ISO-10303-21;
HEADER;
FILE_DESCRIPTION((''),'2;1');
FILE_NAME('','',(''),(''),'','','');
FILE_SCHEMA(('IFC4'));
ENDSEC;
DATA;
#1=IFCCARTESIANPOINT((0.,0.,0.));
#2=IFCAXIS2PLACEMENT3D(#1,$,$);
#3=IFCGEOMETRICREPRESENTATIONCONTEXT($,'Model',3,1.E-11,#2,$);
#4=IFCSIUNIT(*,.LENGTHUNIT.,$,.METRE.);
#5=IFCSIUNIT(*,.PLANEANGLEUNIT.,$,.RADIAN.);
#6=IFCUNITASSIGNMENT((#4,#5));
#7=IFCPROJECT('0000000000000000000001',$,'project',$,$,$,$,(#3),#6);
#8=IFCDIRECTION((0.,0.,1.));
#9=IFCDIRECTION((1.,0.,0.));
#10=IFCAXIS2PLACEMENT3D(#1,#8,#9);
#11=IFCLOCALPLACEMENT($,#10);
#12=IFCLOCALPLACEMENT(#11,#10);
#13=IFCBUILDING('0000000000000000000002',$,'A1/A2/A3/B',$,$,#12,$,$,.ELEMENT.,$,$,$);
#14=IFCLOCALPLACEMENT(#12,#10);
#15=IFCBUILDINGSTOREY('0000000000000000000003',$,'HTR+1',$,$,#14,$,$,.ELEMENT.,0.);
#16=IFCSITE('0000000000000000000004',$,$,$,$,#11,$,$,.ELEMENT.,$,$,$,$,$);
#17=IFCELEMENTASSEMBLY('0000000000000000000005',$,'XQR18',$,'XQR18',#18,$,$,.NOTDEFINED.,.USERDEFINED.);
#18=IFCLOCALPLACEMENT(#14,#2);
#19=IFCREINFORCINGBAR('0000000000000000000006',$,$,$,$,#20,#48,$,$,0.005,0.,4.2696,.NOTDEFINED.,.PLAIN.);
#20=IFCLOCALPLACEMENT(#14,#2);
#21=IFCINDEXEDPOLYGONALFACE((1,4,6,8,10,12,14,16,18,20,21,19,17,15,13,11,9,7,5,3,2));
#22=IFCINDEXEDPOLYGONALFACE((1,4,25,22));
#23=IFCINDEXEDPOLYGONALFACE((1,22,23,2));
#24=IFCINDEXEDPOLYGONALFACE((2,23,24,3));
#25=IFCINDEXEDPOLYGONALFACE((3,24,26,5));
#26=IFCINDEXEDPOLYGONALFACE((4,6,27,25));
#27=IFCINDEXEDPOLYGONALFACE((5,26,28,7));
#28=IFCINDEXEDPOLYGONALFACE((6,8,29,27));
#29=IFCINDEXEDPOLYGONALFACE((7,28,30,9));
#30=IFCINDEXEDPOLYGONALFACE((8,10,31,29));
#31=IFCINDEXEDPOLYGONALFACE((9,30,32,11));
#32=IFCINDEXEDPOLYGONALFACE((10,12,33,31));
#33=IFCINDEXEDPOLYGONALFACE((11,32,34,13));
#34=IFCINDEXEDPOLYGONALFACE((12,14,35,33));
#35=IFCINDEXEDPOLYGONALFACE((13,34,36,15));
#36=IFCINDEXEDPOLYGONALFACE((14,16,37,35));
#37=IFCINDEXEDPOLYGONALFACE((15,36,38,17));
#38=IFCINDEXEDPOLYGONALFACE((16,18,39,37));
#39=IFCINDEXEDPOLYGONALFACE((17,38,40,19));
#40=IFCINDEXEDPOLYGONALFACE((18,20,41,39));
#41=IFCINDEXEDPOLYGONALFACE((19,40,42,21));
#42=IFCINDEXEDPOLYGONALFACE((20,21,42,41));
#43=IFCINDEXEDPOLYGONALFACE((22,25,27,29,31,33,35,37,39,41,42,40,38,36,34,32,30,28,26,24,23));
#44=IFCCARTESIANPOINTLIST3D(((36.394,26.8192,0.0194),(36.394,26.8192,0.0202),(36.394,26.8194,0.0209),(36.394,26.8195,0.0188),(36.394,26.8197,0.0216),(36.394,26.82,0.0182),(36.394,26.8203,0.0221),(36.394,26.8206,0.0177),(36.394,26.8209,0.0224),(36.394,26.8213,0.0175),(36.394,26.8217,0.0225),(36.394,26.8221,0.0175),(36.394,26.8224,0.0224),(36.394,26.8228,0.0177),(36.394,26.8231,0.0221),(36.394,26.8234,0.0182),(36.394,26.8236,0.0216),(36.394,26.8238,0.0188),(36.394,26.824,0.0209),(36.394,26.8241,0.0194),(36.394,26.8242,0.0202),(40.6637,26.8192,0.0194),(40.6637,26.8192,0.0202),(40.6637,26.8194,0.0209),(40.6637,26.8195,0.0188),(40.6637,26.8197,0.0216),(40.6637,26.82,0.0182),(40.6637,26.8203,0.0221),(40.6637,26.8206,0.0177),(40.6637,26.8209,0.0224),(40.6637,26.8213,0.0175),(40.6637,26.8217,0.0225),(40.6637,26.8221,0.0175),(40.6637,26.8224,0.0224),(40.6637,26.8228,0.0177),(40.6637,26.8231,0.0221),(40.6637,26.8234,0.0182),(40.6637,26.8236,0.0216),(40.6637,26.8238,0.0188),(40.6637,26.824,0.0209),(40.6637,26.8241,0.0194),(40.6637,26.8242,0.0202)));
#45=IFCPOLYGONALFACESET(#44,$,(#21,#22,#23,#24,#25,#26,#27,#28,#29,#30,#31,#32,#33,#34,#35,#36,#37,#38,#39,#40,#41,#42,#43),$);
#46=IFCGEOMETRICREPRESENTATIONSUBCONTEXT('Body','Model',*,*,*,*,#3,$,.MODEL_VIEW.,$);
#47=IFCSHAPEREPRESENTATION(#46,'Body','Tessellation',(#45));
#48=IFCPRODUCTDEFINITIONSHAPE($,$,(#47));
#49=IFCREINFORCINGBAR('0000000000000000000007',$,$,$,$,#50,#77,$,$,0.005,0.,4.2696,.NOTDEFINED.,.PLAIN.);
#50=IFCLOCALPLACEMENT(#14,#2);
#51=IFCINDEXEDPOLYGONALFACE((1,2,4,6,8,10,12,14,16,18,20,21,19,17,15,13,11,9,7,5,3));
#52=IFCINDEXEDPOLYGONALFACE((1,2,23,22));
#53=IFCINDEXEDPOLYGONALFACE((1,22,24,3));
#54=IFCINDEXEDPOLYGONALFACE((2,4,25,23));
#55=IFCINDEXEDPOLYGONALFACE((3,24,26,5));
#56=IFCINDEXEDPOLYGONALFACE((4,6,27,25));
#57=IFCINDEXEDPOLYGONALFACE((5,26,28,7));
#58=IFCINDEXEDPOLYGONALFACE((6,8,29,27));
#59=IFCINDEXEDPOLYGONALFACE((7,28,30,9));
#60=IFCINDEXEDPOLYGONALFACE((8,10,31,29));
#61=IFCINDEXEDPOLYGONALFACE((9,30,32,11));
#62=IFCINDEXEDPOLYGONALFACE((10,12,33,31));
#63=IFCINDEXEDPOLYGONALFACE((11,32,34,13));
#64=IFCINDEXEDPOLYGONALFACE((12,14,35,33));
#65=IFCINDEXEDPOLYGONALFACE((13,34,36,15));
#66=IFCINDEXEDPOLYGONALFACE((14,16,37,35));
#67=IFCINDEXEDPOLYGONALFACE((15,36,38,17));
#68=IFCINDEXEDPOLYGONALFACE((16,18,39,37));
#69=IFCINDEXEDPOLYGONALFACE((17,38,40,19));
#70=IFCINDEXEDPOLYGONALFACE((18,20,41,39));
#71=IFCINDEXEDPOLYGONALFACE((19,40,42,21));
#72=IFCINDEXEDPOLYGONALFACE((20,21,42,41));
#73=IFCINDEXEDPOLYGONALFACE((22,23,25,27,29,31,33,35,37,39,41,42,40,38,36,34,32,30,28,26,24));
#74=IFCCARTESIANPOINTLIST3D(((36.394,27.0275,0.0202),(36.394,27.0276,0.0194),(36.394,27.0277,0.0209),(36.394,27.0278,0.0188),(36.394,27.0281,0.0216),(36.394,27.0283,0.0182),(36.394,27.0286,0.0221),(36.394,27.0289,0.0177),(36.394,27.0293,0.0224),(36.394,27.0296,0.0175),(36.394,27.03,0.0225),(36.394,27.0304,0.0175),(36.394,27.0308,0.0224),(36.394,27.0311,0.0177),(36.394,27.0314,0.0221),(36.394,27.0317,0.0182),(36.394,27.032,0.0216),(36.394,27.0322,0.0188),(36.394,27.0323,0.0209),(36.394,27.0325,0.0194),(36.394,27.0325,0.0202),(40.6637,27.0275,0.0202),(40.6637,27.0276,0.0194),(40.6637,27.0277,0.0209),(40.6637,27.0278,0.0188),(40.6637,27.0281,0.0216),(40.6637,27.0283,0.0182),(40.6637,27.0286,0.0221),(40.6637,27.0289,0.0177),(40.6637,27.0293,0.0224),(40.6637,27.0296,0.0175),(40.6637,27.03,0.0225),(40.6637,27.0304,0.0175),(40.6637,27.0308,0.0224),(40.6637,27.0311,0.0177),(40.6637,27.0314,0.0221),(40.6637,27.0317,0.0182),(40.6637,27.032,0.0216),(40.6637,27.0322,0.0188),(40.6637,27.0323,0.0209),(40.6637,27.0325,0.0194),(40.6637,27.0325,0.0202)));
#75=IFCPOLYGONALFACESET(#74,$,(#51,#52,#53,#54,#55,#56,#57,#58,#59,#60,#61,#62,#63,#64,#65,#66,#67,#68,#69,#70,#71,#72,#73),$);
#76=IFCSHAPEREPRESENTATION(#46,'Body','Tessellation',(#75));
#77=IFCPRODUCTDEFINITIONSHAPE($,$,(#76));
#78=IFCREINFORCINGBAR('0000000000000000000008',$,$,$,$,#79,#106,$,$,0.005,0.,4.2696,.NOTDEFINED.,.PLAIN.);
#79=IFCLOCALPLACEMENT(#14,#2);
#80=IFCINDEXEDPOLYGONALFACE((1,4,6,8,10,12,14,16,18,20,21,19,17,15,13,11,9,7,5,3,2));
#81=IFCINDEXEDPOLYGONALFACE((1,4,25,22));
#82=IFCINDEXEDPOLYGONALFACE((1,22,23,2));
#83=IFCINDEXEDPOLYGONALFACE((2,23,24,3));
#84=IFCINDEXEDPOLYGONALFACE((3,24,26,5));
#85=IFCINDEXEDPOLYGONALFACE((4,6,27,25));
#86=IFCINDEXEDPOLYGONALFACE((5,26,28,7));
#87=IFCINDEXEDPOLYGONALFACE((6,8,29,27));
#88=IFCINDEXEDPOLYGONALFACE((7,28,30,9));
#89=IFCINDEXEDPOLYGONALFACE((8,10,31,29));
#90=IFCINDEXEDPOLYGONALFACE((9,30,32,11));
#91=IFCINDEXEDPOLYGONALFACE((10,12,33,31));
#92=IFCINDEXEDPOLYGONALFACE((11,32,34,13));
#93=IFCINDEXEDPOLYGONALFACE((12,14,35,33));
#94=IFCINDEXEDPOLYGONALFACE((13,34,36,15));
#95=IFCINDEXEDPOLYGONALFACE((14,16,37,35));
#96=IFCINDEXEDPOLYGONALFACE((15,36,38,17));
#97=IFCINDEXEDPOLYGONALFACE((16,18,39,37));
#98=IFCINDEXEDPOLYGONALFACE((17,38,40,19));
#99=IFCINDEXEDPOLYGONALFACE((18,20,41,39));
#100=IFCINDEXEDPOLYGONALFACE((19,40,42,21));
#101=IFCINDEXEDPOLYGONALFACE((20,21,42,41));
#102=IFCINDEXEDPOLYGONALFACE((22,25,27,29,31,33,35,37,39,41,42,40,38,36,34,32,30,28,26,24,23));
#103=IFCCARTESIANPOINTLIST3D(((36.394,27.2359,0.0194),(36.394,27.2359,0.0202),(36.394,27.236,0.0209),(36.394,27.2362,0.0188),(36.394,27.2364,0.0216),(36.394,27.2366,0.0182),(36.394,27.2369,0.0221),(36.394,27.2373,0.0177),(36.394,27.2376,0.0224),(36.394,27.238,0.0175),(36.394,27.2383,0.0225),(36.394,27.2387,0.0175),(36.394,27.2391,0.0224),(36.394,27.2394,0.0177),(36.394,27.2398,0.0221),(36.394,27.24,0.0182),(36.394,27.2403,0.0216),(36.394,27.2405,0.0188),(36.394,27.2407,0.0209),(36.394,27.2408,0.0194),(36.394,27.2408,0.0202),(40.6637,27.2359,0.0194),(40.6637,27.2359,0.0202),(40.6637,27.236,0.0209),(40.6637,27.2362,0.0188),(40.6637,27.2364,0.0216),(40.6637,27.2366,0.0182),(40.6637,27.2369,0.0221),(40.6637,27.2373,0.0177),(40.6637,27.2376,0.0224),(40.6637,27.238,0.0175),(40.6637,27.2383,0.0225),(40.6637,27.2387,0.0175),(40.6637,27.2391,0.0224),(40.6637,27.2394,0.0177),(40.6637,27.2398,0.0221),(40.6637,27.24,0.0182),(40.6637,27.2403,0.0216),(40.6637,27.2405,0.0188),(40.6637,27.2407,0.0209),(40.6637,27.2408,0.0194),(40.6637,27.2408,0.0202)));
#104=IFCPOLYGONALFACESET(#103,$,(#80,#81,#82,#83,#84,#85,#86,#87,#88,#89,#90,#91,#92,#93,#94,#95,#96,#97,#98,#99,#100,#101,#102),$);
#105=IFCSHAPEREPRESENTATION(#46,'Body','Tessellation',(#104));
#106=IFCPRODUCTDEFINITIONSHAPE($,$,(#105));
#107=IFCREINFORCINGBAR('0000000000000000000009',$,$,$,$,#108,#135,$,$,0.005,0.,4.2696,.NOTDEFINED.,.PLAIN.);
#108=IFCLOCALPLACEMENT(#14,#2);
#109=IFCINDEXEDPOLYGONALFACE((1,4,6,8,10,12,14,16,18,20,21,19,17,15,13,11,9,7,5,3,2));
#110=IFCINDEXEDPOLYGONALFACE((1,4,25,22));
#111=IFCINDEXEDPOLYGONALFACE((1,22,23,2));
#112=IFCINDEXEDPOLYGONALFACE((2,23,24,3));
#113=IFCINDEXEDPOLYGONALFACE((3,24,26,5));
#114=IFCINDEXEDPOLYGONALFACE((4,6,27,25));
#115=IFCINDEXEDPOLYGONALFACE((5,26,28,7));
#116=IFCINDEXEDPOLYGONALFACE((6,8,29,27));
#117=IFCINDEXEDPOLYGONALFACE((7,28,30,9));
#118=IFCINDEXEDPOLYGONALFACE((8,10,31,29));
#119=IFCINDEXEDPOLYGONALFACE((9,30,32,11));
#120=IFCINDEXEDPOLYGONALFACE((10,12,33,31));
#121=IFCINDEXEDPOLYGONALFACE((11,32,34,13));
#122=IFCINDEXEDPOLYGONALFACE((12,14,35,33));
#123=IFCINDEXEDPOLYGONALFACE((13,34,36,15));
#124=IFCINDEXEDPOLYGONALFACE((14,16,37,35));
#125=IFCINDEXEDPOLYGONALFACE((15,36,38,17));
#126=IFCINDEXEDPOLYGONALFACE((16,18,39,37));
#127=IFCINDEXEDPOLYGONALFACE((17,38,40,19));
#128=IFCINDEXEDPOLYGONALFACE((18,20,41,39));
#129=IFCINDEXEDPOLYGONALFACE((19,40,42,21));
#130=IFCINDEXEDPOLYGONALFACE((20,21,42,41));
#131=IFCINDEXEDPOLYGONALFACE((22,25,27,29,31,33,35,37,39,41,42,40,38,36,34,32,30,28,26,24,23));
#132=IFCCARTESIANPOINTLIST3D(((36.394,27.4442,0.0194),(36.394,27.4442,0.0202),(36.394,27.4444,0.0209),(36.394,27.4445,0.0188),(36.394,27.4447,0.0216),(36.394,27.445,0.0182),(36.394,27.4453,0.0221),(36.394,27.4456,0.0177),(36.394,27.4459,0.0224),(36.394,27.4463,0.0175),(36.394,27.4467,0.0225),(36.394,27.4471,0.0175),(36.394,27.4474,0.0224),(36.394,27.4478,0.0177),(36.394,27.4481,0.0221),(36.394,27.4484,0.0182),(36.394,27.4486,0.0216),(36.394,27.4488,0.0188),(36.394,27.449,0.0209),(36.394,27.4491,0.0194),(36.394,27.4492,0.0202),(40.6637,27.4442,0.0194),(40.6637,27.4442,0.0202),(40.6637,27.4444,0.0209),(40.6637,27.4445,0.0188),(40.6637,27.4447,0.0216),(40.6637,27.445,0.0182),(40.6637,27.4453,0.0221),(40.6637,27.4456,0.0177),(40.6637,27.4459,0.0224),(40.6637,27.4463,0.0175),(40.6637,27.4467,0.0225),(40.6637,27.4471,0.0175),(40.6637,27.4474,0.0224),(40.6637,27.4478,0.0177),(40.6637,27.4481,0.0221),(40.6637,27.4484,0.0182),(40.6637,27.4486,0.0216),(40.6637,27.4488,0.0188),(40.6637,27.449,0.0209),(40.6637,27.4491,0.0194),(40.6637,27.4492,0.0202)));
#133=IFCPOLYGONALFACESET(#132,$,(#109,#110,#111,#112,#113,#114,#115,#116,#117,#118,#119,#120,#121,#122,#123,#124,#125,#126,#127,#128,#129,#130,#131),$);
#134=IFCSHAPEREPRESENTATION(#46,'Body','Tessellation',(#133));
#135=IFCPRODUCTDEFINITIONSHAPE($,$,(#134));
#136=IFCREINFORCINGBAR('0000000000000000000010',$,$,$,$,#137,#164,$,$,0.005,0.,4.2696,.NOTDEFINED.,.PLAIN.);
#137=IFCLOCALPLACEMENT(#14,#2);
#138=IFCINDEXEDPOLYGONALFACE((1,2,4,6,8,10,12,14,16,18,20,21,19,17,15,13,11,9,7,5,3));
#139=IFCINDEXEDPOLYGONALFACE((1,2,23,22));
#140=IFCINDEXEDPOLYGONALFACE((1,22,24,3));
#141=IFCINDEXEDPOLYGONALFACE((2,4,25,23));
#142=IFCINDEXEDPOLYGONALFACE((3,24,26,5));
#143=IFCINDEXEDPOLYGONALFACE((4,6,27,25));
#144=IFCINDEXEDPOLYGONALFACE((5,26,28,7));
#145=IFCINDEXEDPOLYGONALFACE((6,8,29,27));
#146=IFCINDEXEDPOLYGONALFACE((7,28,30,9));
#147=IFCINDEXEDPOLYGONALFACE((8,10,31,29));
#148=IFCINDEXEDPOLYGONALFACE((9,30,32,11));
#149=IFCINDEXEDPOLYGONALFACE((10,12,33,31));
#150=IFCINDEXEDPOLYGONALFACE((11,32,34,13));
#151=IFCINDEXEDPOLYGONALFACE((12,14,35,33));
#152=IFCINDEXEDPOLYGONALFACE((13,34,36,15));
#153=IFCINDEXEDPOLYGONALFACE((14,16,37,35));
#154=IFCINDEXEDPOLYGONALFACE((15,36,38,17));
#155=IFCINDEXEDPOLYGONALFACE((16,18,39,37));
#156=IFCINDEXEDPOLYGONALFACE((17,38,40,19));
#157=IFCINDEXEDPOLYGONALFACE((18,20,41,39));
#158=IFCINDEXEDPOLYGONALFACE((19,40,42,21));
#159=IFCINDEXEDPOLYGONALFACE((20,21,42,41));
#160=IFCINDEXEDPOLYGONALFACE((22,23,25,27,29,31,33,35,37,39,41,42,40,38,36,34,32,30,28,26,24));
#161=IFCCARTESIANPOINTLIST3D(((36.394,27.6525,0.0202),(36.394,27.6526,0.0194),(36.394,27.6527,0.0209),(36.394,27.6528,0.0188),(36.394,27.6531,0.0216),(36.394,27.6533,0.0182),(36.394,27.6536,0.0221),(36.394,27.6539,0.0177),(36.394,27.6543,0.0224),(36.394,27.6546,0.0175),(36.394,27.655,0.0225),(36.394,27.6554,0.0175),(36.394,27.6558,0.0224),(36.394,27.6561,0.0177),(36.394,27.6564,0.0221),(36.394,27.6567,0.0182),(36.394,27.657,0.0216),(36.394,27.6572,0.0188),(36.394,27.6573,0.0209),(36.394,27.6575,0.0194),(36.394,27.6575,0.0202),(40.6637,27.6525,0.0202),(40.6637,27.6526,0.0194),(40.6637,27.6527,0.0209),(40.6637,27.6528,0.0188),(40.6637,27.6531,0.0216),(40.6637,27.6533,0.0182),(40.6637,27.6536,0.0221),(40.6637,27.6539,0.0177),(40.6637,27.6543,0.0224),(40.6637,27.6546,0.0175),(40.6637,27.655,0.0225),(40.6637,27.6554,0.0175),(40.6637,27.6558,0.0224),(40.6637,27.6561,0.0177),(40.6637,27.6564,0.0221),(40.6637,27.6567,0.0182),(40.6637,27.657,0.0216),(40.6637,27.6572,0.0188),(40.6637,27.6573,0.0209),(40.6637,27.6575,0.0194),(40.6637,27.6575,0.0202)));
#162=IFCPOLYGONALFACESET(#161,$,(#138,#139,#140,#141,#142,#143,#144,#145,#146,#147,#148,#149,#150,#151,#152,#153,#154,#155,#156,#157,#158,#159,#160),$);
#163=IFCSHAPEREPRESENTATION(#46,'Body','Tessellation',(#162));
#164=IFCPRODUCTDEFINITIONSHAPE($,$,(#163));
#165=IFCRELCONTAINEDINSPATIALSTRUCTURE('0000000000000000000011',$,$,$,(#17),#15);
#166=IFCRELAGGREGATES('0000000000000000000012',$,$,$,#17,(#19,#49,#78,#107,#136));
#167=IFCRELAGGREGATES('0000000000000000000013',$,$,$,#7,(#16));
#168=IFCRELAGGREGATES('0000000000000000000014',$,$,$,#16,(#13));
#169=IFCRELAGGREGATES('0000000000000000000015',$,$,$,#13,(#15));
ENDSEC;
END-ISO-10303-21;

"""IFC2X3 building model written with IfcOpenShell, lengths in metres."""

from ifc_helpers import new_model, entity, si_unit, origin, origin_with_axes, place, context, subcontext, project, spatial, shape, element, aggregate, save


model = new_model("IFC2X3")

# Units and contexts
model_context = context("Model", 3, precision=1e-11, world=origin())
body_context = subcontext(model_context, "Body", "Model", "MODEL_VIEW")
ifc_project = project(units=[si_unit("LENGTHUNIT", "METRE"), si_unit("PLANEANGLEUNIT", "RADIAN")], contexts=[model_context])

# Site, building, storey
site_placement = place(None, origin_with_axes())
site = spatial("IfcSite", under=ifc_project, at=site_placement, CompositionType="ELEMENT")
building_placement = place(site_placement, origin_with_axes())
building = spatial("IfcBuilding", under=site, at=building_placement, Name="A1/A2/A3/B", CompositionType="ELEMENT")
storey_placement = place(building_placement, origin_with_axes())
storey = spatial("IfcBuildingStorey", under=building, at=storey_placement, Name="HTR+1", CompositionType="ELEMENT", Elevation=0.0)

# Element assembly, reinforcing bars
assembly_1_placement = place(storey_placement, origin_with_axes())
assembly_1 = element("IfcElementAssembly", 1, at=assembly_1_placement, inside=storey, Name="XQR18", ObjectType="XQR18", AssemblyPlace="NOTDEFINED", PredefinedType="USERDEFINED")
reinforcing_bar_1_placement = place(assembly_1_placement, origin_with_axes())
reinforcing_bar_1 = element("IfcReinforcingBar", 2, at=reinforcing_bar_1_placement, BarLength=4.2696, BarRole="NOTDEFINED", BarSurface="PLAIN", CrossSectionArea=0.0, NominalDiameter=0.005, shapes=[
    shape(body_context, "Body", "AdvancedSweptSolid", [entity("IfcSweptDiskSolid", entity("IfcPolyline", [entity("IfcCartesianPoint", [36.394, 26.8217, 0.02]), entity("IfcCartesianPoint", [40.6637, 26.8217, 0.02])]), 0.0025, None, 0.0, 4.2696)]),
    shape(body_context, "Body", "AdvancedSweptSolid", [entity("IfcSweptDiskSolid", entity("IfcPolyline", [entity("IfcCartesianPoint", [36.394, 26.8217, 0.02]), entity("IfcCartesianPoint", [40.6637, 26.8217, 0.02])]), 0.0025, None, 0.0, 4.2696)]),
])
reinforcing_bar_2_placement = place(assembly_1_placement, origin_with_axes())
reinforcing_bar_2 = element("IfcReinforcingBar", 3, at=reinforcing_bar_2_placement, BarLength=4.2696, BarRole="NOTDEFINED", BarSurface="PLAIN", CrossSectionArea=0.0, NominalDiameter=0.005, shapes=[
    shape(body_context, "Body", "AdvancedSweptSolid", [entity("IfcSweptDiskSolid", entity("IfcPolyline", [entity("IfcCartesianPoint", [36.394, 27.03, 0.02]), entity("IfcCartesianPoint", [40.6637, 27.03, 0.02])]), 0.0025, None, 0.0, 4.2696)]),
    shape(body_context, "Body", "AdvancedSweptSolid", [entity("IfcSweptDiskSolid", entity("IfcPolyline", [entity("IfcCartesianPoint", [36.394, 27.03, 0.02]), entity("IfcCartesianPoint", [40.6637, 27.03, 0.02])]), 0.0025, None, 0.0, 4.2696)]),
])
reinforcing_bar_3_placement = place(assembly_1_placement, origin_with_axes())
reinforcing_bar_3 = element("IfcReinforcingBar", 4, at=reinforcing_bar_3_placement, BarLength=4.2696, BarRole="NOTDEFINED", BarSurface="PLAIN", CrossSectionArea=0.0, NominalDiameter=0.005, shapes=[
    shape(body_context, "Body", "AdvancedSweptSolid", [entity("IfcSweptDiskSolid", entity("IfcPolyline", [entity("IfcCartesianPoint", [36.394, 27.2383, 0.02]), entity("IfcCartesianPoint", [40.6637, 27.2383, 0.02])]), 0.0025, None, 0.0, 4.2696)]),
    shape(body_context, "Body", "AdvancedSweptSolid", [entity("IfcSweptDiskSolid", entity("IfcPolyline", [entity("IfcCartesianPoint", [36.394, 27.2383, 0.02]), entity("IfcCartesianPoint", [40.6637, 27.2383, 0.02])]), 0.0025, None, 0.0, 4.2696)]),
])
reinforcing_bar_4_placement = place(assembly_1_placement, origin_with_axes())
reinforcing_bar_4 = element("IfcReinforcingBar", 5, at=reinforcing_bar_4_placement, BarLength=4.2696, BarRole="NOTDEFINED", BarSurface="PLAIN", CrossSectionArea=0.0, NominalDiameter=0.005, shapes=[
    shape(body_context, "Body", "AdvancedSweptSolid", [entity("IfcSweptDiskSolid", entity("IfcPolyline", [entity("IfcCartesianPoint", [36.394, 27.4467, 0.02]), entity("IfcCartesianPoint", [40.6637, 27.4467, 0.02])]), 0.0025, None, 0.0, 4.2696)]),
    shape(body_context, "Body", "AdvancedSweptSolid", [entity("IfcSweptDiskSolid", entity("IfcPolyline", [entity("IfcCartesianPoint", [36.394, 27.4467, 0.02]), entity("IfcCartesianPoint", [40.6637, 27.4467, 0.02])]), 0.0025, None, 0.0, 4.2696)]),
])
reinforcing_bar_5_placement = place(assembly_1_placement, origin_with_axes())
reinforcing_bar_5 = element("IfcReinforcingBar", 6, at=reinforcing_bar_5_placement, BarLength=4.2696, BarRole="NOTDEFINED", BarSurface="PLAIN", CrossSectionArea=0.0, NominalDiameter=0.005, shapes=[
    shape(body_context, "Body", "AdvancedSweptSolid", [entity("IfcSweptDiskSolid", entity("IfcPolyline", [entity("IfcCartesianPoint", [36.394, 27.655, 0.02]), entity("IfcCartesianPoint", [40.6637, 27.655, 0.02])]), 0.0025, None, 0.0, 4.2696)]),
    shape(body_context, "Body", "AdvancedSweptSolid", [entity("IfcSweptDiskSolid", entity("IfcPolyline", [entity("IfcCartesianPoint", [36.394, 27.655, 0.02]), entity("IfcCartesianPoint", [40.6637, 27.655, 0.02])]), 0.0025, None, 0.0, 4.2696)]),
])
aggregate(assembly_1, [reinforcing_bar_1, reinforcing_bar_2, reinforcing_bar_3, reinforcing_bar_4, reinforcing_bar_5])

save(model, "model.ifc")
